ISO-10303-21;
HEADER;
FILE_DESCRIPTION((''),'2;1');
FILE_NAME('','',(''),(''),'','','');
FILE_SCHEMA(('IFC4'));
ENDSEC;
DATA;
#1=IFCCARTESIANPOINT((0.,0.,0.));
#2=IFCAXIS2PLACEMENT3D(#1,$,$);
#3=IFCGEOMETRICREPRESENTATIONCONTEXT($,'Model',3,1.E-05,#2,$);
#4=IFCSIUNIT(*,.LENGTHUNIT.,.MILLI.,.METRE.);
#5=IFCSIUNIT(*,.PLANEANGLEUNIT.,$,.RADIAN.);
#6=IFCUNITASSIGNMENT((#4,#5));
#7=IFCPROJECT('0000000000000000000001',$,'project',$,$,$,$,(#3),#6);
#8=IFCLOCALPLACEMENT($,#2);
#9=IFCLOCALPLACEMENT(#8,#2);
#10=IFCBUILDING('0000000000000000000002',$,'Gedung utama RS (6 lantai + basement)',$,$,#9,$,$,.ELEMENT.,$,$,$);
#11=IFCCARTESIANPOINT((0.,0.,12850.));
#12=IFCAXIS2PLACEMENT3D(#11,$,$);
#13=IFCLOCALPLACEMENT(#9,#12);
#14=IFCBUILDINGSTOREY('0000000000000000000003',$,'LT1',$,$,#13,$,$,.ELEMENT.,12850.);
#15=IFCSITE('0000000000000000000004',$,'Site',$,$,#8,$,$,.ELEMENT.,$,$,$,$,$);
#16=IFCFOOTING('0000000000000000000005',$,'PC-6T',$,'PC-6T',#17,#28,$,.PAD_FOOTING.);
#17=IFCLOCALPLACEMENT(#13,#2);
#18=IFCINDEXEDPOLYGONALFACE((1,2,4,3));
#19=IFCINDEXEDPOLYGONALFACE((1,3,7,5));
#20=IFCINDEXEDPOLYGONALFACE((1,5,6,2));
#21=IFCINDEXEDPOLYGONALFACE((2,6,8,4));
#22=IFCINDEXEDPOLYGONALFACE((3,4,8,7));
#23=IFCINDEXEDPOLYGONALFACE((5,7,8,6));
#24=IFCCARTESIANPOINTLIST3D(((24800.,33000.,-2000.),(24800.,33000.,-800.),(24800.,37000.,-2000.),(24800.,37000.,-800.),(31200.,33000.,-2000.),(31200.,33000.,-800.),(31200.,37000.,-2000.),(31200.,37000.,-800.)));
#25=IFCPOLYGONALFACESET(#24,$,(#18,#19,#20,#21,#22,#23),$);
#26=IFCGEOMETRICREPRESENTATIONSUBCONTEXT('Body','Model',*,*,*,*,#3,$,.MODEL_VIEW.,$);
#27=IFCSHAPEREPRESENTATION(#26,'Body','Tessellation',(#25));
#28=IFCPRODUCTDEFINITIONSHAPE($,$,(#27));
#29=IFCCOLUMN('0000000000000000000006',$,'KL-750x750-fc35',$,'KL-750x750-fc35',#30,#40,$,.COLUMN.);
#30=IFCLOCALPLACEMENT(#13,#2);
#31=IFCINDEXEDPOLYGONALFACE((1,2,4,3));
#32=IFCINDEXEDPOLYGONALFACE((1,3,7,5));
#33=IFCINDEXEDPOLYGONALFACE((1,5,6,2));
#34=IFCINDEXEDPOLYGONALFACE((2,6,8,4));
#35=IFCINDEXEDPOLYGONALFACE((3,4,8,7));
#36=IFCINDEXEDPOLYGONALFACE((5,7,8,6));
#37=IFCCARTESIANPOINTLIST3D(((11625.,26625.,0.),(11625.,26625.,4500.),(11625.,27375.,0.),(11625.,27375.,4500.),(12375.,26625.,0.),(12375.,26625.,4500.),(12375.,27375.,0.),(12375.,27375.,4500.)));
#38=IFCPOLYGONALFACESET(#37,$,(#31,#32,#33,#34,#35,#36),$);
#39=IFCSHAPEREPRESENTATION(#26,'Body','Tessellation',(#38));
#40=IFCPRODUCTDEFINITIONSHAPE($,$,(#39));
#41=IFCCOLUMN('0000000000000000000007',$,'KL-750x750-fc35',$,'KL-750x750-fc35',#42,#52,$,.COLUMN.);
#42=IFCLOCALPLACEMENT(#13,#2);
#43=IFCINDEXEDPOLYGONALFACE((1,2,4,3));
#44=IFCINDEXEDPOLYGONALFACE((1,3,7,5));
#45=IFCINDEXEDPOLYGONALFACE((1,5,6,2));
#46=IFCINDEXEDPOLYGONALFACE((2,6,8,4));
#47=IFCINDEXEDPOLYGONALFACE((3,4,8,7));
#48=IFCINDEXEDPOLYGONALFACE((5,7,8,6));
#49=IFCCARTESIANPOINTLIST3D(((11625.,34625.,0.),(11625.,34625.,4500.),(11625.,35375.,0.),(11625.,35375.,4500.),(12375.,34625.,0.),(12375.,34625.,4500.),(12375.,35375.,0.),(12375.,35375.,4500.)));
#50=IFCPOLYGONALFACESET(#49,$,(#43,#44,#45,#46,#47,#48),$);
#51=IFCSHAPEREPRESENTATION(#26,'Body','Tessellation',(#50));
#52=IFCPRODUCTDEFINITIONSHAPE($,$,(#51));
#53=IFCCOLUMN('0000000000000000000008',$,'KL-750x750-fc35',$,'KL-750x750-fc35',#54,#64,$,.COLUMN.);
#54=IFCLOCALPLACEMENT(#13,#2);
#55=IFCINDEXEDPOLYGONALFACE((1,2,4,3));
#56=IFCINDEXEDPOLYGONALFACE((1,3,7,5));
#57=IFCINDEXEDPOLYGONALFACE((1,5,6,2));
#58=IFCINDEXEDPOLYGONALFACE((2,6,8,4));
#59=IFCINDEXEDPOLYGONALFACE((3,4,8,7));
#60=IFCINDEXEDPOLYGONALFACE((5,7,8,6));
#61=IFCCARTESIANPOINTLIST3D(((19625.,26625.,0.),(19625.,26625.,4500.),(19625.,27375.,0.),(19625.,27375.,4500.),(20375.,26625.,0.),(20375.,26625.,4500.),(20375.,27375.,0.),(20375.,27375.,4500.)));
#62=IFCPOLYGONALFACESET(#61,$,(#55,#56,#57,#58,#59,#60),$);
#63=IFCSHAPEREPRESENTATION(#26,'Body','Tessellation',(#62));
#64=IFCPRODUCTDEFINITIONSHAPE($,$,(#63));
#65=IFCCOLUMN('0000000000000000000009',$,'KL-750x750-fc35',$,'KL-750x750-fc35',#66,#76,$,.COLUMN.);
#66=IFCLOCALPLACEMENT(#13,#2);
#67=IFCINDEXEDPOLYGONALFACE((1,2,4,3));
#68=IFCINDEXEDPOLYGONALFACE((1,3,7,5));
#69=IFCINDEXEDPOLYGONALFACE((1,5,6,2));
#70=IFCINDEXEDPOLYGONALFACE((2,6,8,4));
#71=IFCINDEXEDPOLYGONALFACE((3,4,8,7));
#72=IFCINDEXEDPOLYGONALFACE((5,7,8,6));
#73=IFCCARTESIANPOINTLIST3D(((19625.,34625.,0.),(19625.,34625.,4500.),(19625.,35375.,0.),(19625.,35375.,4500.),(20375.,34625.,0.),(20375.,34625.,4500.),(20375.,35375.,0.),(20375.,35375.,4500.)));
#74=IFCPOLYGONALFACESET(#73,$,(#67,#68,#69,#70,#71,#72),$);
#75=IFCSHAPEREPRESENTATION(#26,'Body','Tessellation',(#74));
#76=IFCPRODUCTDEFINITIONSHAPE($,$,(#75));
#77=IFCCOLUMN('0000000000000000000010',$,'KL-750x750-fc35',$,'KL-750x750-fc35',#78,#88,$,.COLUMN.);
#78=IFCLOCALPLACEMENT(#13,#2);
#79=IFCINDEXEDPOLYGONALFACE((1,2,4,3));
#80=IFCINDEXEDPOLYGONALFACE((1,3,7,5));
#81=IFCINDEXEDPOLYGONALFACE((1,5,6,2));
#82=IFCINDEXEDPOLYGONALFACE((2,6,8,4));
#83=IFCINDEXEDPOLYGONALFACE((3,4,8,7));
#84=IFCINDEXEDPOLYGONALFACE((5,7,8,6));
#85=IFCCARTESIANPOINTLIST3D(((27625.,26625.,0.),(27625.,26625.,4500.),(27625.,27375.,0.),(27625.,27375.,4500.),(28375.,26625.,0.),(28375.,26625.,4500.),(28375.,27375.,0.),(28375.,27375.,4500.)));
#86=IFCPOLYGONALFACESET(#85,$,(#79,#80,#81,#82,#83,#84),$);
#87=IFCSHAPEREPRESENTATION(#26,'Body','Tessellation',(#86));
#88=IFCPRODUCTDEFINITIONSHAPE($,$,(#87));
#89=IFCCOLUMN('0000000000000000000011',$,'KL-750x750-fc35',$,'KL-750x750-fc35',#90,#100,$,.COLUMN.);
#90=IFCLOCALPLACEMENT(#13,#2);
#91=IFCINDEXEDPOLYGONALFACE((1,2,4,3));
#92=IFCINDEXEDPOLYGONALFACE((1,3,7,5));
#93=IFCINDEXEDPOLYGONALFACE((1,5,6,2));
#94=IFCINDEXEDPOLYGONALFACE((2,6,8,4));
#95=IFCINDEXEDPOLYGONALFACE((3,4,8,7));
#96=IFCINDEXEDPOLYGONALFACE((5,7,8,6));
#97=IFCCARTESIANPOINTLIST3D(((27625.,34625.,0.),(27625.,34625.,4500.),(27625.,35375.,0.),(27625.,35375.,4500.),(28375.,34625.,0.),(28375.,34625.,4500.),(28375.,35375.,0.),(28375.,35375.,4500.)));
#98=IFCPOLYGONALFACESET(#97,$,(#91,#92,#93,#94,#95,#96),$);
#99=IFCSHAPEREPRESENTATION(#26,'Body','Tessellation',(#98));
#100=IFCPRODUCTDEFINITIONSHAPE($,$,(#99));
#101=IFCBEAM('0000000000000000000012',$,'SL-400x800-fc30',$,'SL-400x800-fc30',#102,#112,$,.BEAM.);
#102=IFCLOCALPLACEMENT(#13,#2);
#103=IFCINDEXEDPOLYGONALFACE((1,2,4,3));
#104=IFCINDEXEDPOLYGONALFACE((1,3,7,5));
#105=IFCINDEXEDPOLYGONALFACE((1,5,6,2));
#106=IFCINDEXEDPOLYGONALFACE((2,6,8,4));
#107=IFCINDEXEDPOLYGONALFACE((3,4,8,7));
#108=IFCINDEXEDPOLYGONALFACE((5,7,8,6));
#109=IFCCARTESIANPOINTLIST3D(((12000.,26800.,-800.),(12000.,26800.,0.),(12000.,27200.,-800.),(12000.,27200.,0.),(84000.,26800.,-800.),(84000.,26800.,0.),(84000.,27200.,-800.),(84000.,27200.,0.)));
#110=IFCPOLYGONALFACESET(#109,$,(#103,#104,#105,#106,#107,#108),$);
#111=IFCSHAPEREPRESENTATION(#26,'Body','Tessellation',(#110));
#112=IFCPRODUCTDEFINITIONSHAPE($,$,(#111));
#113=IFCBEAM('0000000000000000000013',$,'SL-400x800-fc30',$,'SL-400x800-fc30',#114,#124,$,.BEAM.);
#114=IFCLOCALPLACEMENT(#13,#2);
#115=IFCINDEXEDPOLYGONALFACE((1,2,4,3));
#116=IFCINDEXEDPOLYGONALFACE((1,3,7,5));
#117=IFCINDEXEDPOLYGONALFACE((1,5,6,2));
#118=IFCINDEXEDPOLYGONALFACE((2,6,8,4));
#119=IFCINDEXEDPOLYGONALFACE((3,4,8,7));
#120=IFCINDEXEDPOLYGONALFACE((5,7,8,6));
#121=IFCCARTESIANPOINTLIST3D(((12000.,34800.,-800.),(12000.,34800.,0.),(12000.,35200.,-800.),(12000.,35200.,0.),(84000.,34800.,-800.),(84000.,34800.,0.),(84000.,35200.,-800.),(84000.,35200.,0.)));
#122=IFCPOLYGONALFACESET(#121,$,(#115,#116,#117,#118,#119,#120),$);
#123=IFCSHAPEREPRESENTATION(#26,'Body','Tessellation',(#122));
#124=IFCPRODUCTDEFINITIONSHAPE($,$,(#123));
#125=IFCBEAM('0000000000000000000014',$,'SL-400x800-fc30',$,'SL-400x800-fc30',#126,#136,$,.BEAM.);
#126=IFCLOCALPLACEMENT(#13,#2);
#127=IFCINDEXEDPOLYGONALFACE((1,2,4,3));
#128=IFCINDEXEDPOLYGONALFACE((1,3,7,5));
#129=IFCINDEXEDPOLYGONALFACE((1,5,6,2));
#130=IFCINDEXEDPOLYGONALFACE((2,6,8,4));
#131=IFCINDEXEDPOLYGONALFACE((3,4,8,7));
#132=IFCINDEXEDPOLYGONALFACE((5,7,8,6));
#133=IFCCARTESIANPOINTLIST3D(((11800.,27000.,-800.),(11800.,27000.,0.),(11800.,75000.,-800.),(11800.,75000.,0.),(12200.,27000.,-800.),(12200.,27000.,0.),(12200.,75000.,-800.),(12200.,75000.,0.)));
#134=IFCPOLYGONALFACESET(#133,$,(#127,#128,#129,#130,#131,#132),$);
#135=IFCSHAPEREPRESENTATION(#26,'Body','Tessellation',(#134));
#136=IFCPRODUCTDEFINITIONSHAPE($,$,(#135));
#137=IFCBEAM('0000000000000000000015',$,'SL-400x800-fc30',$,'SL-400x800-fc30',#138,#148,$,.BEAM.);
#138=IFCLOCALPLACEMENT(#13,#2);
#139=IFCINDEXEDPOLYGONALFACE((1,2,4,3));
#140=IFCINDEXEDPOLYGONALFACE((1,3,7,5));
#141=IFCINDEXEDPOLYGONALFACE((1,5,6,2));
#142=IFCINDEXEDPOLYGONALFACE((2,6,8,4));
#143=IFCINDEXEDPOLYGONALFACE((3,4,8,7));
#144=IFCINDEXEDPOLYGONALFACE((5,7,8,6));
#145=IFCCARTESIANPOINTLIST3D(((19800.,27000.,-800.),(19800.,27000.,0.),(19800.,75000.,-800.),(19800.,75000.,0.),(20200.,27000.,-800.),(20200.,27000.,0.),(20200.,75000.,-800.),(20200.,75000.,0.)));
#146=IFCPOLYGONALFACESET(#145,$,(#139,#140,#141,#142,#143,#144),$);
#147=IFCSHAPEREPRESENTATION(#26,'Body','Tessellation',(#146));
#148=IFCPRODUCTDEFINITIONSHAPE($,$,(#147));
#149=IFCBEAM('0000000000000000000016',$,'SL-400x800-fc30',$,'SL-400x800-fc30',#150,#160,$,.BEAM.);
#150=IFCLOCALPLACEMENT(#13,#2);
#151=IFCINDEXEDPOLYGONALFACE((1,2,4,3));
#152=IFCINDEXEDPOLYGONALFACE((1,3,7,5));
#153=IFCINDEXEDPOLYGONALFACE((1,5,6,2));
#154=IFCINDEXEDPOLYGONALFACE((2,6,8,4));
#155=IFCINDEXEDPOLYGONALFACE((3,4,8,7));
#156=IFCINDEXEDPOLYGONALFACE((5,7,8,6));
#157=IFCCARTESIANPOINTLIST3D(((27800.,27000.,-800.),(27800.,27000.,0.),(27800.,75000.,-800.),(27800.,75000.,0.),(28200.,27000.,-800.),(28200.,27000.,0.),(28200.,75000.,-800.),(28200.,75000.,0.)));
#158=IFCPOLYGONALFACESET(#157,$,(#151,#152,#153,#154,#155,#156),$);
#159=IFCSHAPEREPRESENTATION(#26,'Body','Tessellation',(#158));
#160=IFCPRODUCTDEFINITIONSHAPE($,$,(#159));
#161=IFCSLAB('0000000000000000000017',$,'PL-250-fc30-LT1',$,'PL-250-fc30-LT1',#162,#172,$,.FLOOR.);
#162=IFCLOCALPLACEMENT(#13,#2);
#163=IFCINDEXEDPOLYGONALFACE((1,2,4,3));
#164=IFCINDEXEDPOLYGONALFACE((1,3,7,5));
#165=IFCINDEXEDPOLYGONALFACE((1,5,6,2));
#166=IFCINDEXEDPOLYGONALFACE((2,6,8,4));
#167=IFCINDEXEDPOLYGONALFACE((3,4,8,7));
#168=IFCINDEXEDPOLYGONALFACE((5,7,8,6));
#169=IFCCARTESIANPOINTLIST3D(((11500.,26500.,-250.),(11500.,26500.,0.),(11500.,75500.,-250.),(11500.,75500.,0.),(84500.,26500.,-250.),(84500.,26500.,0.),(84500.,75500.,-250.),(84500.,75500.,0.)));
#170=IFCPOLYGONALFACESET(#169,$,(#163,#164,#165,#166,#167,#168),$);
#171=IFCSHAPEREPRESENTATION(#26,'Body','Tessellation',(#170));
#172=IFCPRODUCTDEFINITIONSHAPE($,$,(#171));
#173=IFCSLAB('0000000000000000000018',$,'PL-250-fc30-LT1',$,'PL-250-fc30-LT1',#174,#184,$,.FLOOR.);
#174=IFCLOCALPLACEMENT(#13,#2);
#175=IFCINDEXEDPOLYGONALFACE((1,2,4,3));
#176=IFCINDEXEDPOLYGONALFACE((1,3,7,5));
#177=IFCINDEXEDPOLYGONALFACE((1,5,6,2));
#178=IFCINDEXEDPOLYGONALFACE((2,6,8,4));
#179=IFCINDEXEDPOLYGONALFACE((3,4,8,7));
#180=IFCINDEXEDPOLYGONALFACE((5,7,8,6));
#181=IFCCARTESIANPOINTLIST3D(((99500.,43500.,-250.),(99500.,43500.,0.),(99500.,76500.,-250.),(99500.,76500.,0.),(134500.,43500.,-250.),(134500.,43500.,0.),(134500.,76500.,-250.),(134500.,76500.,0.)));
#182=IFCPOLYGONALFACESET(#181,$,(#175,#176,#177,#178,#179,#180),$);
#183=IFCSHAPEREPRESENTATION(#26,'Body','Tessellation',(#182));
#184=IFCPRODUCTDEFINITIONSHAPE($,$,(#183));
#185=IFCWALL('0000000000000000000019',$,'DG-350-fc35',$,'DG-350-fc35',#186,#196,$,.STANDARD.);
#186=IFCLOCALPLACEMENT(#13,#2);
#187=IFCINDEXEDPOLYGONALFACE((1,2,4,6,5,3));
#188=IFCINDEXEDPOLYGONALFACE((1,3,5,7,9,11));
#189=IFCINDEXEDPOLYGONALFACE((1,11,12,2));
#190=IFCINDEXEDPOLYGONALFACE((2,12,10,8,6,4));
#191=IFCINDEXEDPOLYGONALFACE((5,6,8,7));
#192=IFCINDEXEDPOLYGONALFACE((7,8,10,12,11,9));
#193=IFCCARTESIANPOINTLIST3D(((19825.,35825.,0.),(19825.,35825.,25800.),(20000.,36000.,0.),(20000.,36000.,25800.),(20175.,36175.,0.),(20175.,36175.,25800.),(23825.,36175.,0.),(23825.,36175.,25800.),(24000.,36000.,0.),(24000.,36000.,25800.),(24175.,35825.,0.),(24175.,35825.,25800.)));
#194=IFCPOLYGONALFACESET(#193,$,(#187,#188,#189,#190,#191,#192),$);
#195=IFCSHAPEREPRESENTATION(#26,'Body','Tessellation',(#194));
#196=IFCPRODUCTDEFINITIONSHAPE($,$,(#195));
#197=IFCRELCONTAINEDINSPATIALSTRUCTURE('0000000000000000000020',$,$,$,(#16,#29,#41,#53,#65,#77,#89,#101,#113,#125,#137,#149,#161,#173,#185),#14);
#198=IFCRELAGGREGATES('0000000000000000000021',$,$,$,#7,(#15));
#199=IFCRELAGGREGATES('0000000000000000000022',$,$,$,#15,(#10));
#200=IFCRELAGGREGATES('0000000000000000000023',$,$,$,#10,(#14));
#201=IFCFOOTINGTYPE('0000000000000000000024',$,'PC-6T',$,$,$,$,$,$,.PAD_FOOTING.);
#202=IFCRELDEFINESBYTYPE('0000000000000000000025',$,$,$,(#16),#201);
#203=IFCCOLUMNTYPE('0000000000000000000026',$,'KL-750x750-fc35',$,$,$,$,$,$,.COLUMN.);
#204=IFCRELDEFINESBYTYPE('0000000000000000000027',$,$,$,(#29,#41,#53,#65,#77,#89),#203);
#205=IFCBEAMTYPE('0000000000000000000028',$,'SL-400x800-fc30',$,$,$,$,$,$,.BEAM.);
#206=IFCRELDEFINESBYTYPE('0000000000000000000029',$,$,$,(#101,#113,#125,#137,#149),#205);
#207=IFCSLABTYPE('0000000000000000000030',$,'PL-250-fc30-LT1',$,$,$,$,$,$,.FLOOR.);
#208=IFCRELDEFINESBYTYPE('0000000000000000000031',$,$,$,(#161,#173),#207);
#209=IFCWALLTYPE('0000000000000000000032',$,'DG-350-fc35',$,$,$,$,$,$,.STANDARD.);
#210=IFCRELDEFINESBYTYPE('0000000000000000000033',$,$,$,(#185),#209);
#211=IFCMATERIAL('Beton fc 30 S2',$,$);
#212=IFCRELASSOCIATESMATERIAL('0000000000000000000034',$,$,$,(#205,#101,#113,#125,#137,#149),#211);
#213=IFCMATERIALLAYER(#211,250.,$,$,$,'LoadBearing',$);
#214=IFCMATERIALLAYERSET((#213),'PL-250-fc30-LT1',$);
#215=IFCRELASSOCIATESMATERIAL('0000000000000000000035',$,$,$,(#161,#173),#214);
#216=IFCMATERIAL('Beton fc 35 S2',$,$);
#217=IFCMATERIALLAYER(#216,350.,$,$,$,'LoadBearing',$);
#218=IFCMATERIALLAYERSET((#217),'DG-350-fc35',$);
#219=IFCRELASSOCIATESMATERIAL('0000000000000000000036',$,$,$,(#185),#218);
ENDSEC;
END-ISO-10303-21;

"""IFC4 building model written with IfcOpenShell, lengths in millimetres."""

from ifc_helpers import new_model, si_unit, frame, origin, origin_2d, place, context, subcontext, project, spatial, polyline, rectangle, outline, extrude, material, layer, layer_set, layer_usage, material_profile, profile_set, profile_usage, type_object, element, save


model = new_model("IFC4")

# Units and contexts
model_context = context("Model", 3, precision=1e-05, world=origin())
body_context = subcontext(model_context, "Body", "Model", "MODEL_VIEW")
ifc_project = project(units=[si_unit("LENGTHUNIT", "METRE", prefix="MILLI"), si_unit("PLANEANGLEUNIT", "RADIAN")], contexts=[model_context])

# Site, building, storey
site_placement = place(None, origin())
site = spatial("IfcSite", under=ifc_project, at=site_placement, Name="Site", CompositionType="ELEMENT")
building_placement = place(site_placement, origin())
building = spatial("IfcBuilding", under=site, at=building_placement, Name="Gedung utama RS (6 lantai + basement)", CompositionType="ELEMENT")
storey_placement = place(building_placement, frame((0.0, 0.0, 12850.0)))
storey = spatial("IfcBuildingStorey", under=building, at=storey_placement, Name="LT1", CompositionType="ELEMENT", Elevation=12850.0)

# Footing
ifc_material_profile_1 = material_profile(None, rectangle(XDim=6400.0, YDim=4000.0, at=origin_2d()), Name="PC-6T")
ifc_profile_set_1 = profile_set([ifc_material_profile_1], Name="PC-6T")
ifc_profile_usage_1 = profile_usage(ifc_profile_set_1, cardinal=5)
footing_type_1 = type_object("IfcFootingType", Name="PC-6T", PredefinedType="PAD_FOOTING", material=ifc_profile_set_1)
for number, where, z_axis, x_axis, name in (
    (1, (28000.0, 35000.0, -2000.0), (0.0, 0.0, 1.0), (1.0, 0.0, 0.0), "PC-6T"),
):
    element("IfcFooting", number, at=place(storey_placement, frame(where, z_axis=z_axis, x_axis=x_axis)), inside=storey, type_object=footing_type_1, material=ifc_profile_usage_1, Name=name, ObjectType="PC-6T", PredefinedType="PAD_FOOTING", context=body_context, shape_type="SweptSolid", body=[
        extrude(rectangle(XDim=6400.0, YDim=4000.0, at=origin_2d()), origin(), (0.0, 0.0, 1.0), 1200.0),
    ])

# Columns
ifc_material_profile_2 = material_profile(None, rectangle(XDim=750.0, YDim=750.0, at=origin_2d()), Name="KL-750x750-fc35")
ifc_profile_set_2 = profile_set([ifc_material_profile_2], Name="KL-750x750-fc35")
ifc_profile_usage_2 = profile_usage(ifc_profile_set_2, cardinal=5)
column_type = type_object("IfcColumnType", Name="KL-750x750-fc35", PredefinedType="COLUMN", material=ifc_profile_set_2)
for number, where, z_axis, x_axis, name in (
    (2, (12000.0, 27000.0, 0.0), (0.0, 0.0, 1.0), (1.0, 0.0, 0.0), "KL-750x750-fc35"),
    (3, (12000.0, 35000.0, 0.0), (0.0, 0.0, 1.0), (1.0, 0.0, 0.0), "KL-750x750-fc35"),
    (4, (20000.0, 27000.0, 0.0), (0.0, 0.0, 1.0), (1.0, 0.0, 0.0), "KL-750x750-fc35"),
    (5, (20000.0, 35000.0, 0.0), (0.0, 0.0, 1.0), (1.0, 0.0, 0.0), "KL-750x750-fc35"),
    (6, (28000.0, 27000.0, 0.0), (0.0, 0.0, 1.0), (1.0, 0.0, 0.0), "KL-750x750-fc35"),
    (7, (28000.0, 35000.0, 0.0), (0.0, 0.0, 1.0), (1.0, 0.0, 0.0), "KL-750x750-fc35"),
):
    element("IfcColumn", number, at=place(storey_placement, frame(where, z_axis=z_axis, x_axis=x_axis)), inside=storey, type_object=column_type, material=ifc_profile_usage_2, Name=name, ObjectType="KL-750x750-fc35", PredefinedType="COLUMN", context=body_context, shape_type="SweptSolid", body=[
        extrude(rectangle(XDim=750.0, YDim=750.0, at=origin_2d()), origin(), (0.0, 0.0, 1.0), 4500.0),
    ])

# Beams
ifc_material_1 = material(Name="Beton fc 30 S2")
ifc_material_profile_3 = material_profile(ifc_material_1, rectangle(XDim=400.0, YDim=800.0, at=origin_2d()), Name="SL-400x800-fc30")
ifc_profile_set_3 = profile_set([ifc_material_profile_3], Name="SL-400x800-fc30")
ifc_profile_usage_3 = profile_usage(ifc_profile_set_3, cardinal=8)
beam_type = type_object("IfcBeamType", Name="SL-400x800-fc30", PredefinedType="BEAM", material=ifc_profile_set_3)
for number, where, name in (
    (8, (12000.0, 27000.0, -400.0), "SL-400x800-fc30"),
    (9, (12000.0, 35000.0, -400.0), "SL-400x800-fc30"),
):
    element("IfcBeam", number, at=place(storey_placement, frame(where)), inside=storey, type_object=beam_type, material=ifc_profile_usage_3, Name=name, ObjectType="SL-400x800-fc30", PredefinedType="BEAM", context=body_context, shape_type="SweptSolid", body=[
        extrude(rectangle(XDim=400.0, YDim=800.0, at=origin_2d()), frame((0.0, 0.0, 0.0), z_axis=(1.0, 0.0, 0.0), x_axis=(0.0, 1.0, 0.0)), (0.0, 0.0, 1.0), 72000.0),
    ])
for number, where, name in (
    (10, (12000.0, 27000.0, -400.0), "SL-400x800-fc30"),
    (11, (20000.0, 27000.0, -400.0), "SL-400x800-fc30"),
    (12, (28000.0, 27000.0, -400.0), "SL-400x800-fc30"),
):
    element("IfcBeam", number, at=place(storey_placement, frame(where)), inside=storey, type_object=beam_type, material=ifc_profile_usage_3, Name=name, ObjectType="SL-400x800-fc30", PredefinedType="BEAM", context=body_context, shape_type="SweptSolid", body=[
        extrude(rectangle(XDim=400.0, YDim=800.0, at=origin_2d()), frame((0.0, 0.0, 0.0), z_axis=(0.0, 1.0, 0.0), x_axis=(-1.0, 0.0, 0.0)), (0.0, 0.0, 1.0), 48000.0),
    ])

# Slabs
ifc_layer_1 = layer(ifc_material_1, 250.0, Category="LoadBearing")
ifc_layer_set_1 = layer_set([ifc_layer_1], Name="PL-250-fc30-LT1")
ifc_layer_usage_1 = layer_usage(ifc_layer_set_1, "AXIS3", "NEGATIVE", 0.0)
slab_type = type_object("IfcSlabType", Name="PL-250-fc30-LT1", PredefinedType="FLOOR")
slab_1_placement = place(storey_placement, origin())
element("IfcSlab", 13, at=slab_1_placement, inside=storey, type_object=slab_type, material=ifc_layer_usage_1, Name="PL-250-fc30-LT1", ObjectType="PL-250-fc30-LT1", PredefinedType="FLOOR", context=body_context, shape_type="SweptSolid", body=[
    extrude(outline(polyline([(11500.0, 26500.0), (84500.0, 26500.0), (84500.0, 75500.0), (11500.0, 75500.0), (11500.0, 26500.0)])), frame((0.0, 0.0, -250.0)), (0.0, 0.0, 1.0), 250.0),
])
slab_2_placement = place(storey_placement, origin())
element("IfcSlab", 14, at=slab_2_placement, inside=storey, type_object=slab_type, material=ifc_layer_usage_1, Name="PL-250-fc30-LT1", ObjectType="PL-250-fc30-LT1", PredefinedType="FLOOR", context=body_context, shape_type="SweptSolid", body=[
    extrude(outline(polyline([(99500.0, 43500.0), (134500.0, 43500.0), (134500.0, 76500.0), (99500.0, 76500.0), (99500.0, 43500.0)])), frame((0.0, 0.0, -250.0)), (0.0, 0.0, 1.0), 250.0),
])

# Wall
ifc_material_2 = material(Name="Beton fc 35 S2")
ifc_layer_2 = layer(ifc_material_2, 350.0, Category="LoadBearing")
ifc_layer_set_2 = layer_set([ifc_layer_2], Name="DG-350-fc35")
ifc_layer_usage_2 = layer_usage(ifc_layer_set_2, "AXIS2", "NEGATIVE", 175.0)
wall_type = type_object("IfcWallType", Name="DG-350-fc35", PredefinedType="STANDARD")
wall_1_placement = place(storey_placement, frame((20000.0, 36000.0, 0.0), z_axis=(0.0, 0.0, 1.0), x_axis=(1.0, 0.0, 0.0)))
element("IfcWall", 15, at=wall_1_placement, inside=storey, type_object=wall_type, material=ifc_layer_usage_2, Name="DG-350-fc35", ObjectType="DG-350-fc35", PredefinedType="STANDARD", context=body_context, shape_type="SweptSolid", body=[
    extrude(outline(polyline([(-175.0, -175.0), (0.0, 0.0), (175.0, 175.0), (3825.0, 175.0), (4000.0, 0.0), (4175.0, -175.0), (-175.0, -175.0)])), origin(), (0.0, 0.0, 1.0), 25800.0),
])

save(model, "model.ifc")
